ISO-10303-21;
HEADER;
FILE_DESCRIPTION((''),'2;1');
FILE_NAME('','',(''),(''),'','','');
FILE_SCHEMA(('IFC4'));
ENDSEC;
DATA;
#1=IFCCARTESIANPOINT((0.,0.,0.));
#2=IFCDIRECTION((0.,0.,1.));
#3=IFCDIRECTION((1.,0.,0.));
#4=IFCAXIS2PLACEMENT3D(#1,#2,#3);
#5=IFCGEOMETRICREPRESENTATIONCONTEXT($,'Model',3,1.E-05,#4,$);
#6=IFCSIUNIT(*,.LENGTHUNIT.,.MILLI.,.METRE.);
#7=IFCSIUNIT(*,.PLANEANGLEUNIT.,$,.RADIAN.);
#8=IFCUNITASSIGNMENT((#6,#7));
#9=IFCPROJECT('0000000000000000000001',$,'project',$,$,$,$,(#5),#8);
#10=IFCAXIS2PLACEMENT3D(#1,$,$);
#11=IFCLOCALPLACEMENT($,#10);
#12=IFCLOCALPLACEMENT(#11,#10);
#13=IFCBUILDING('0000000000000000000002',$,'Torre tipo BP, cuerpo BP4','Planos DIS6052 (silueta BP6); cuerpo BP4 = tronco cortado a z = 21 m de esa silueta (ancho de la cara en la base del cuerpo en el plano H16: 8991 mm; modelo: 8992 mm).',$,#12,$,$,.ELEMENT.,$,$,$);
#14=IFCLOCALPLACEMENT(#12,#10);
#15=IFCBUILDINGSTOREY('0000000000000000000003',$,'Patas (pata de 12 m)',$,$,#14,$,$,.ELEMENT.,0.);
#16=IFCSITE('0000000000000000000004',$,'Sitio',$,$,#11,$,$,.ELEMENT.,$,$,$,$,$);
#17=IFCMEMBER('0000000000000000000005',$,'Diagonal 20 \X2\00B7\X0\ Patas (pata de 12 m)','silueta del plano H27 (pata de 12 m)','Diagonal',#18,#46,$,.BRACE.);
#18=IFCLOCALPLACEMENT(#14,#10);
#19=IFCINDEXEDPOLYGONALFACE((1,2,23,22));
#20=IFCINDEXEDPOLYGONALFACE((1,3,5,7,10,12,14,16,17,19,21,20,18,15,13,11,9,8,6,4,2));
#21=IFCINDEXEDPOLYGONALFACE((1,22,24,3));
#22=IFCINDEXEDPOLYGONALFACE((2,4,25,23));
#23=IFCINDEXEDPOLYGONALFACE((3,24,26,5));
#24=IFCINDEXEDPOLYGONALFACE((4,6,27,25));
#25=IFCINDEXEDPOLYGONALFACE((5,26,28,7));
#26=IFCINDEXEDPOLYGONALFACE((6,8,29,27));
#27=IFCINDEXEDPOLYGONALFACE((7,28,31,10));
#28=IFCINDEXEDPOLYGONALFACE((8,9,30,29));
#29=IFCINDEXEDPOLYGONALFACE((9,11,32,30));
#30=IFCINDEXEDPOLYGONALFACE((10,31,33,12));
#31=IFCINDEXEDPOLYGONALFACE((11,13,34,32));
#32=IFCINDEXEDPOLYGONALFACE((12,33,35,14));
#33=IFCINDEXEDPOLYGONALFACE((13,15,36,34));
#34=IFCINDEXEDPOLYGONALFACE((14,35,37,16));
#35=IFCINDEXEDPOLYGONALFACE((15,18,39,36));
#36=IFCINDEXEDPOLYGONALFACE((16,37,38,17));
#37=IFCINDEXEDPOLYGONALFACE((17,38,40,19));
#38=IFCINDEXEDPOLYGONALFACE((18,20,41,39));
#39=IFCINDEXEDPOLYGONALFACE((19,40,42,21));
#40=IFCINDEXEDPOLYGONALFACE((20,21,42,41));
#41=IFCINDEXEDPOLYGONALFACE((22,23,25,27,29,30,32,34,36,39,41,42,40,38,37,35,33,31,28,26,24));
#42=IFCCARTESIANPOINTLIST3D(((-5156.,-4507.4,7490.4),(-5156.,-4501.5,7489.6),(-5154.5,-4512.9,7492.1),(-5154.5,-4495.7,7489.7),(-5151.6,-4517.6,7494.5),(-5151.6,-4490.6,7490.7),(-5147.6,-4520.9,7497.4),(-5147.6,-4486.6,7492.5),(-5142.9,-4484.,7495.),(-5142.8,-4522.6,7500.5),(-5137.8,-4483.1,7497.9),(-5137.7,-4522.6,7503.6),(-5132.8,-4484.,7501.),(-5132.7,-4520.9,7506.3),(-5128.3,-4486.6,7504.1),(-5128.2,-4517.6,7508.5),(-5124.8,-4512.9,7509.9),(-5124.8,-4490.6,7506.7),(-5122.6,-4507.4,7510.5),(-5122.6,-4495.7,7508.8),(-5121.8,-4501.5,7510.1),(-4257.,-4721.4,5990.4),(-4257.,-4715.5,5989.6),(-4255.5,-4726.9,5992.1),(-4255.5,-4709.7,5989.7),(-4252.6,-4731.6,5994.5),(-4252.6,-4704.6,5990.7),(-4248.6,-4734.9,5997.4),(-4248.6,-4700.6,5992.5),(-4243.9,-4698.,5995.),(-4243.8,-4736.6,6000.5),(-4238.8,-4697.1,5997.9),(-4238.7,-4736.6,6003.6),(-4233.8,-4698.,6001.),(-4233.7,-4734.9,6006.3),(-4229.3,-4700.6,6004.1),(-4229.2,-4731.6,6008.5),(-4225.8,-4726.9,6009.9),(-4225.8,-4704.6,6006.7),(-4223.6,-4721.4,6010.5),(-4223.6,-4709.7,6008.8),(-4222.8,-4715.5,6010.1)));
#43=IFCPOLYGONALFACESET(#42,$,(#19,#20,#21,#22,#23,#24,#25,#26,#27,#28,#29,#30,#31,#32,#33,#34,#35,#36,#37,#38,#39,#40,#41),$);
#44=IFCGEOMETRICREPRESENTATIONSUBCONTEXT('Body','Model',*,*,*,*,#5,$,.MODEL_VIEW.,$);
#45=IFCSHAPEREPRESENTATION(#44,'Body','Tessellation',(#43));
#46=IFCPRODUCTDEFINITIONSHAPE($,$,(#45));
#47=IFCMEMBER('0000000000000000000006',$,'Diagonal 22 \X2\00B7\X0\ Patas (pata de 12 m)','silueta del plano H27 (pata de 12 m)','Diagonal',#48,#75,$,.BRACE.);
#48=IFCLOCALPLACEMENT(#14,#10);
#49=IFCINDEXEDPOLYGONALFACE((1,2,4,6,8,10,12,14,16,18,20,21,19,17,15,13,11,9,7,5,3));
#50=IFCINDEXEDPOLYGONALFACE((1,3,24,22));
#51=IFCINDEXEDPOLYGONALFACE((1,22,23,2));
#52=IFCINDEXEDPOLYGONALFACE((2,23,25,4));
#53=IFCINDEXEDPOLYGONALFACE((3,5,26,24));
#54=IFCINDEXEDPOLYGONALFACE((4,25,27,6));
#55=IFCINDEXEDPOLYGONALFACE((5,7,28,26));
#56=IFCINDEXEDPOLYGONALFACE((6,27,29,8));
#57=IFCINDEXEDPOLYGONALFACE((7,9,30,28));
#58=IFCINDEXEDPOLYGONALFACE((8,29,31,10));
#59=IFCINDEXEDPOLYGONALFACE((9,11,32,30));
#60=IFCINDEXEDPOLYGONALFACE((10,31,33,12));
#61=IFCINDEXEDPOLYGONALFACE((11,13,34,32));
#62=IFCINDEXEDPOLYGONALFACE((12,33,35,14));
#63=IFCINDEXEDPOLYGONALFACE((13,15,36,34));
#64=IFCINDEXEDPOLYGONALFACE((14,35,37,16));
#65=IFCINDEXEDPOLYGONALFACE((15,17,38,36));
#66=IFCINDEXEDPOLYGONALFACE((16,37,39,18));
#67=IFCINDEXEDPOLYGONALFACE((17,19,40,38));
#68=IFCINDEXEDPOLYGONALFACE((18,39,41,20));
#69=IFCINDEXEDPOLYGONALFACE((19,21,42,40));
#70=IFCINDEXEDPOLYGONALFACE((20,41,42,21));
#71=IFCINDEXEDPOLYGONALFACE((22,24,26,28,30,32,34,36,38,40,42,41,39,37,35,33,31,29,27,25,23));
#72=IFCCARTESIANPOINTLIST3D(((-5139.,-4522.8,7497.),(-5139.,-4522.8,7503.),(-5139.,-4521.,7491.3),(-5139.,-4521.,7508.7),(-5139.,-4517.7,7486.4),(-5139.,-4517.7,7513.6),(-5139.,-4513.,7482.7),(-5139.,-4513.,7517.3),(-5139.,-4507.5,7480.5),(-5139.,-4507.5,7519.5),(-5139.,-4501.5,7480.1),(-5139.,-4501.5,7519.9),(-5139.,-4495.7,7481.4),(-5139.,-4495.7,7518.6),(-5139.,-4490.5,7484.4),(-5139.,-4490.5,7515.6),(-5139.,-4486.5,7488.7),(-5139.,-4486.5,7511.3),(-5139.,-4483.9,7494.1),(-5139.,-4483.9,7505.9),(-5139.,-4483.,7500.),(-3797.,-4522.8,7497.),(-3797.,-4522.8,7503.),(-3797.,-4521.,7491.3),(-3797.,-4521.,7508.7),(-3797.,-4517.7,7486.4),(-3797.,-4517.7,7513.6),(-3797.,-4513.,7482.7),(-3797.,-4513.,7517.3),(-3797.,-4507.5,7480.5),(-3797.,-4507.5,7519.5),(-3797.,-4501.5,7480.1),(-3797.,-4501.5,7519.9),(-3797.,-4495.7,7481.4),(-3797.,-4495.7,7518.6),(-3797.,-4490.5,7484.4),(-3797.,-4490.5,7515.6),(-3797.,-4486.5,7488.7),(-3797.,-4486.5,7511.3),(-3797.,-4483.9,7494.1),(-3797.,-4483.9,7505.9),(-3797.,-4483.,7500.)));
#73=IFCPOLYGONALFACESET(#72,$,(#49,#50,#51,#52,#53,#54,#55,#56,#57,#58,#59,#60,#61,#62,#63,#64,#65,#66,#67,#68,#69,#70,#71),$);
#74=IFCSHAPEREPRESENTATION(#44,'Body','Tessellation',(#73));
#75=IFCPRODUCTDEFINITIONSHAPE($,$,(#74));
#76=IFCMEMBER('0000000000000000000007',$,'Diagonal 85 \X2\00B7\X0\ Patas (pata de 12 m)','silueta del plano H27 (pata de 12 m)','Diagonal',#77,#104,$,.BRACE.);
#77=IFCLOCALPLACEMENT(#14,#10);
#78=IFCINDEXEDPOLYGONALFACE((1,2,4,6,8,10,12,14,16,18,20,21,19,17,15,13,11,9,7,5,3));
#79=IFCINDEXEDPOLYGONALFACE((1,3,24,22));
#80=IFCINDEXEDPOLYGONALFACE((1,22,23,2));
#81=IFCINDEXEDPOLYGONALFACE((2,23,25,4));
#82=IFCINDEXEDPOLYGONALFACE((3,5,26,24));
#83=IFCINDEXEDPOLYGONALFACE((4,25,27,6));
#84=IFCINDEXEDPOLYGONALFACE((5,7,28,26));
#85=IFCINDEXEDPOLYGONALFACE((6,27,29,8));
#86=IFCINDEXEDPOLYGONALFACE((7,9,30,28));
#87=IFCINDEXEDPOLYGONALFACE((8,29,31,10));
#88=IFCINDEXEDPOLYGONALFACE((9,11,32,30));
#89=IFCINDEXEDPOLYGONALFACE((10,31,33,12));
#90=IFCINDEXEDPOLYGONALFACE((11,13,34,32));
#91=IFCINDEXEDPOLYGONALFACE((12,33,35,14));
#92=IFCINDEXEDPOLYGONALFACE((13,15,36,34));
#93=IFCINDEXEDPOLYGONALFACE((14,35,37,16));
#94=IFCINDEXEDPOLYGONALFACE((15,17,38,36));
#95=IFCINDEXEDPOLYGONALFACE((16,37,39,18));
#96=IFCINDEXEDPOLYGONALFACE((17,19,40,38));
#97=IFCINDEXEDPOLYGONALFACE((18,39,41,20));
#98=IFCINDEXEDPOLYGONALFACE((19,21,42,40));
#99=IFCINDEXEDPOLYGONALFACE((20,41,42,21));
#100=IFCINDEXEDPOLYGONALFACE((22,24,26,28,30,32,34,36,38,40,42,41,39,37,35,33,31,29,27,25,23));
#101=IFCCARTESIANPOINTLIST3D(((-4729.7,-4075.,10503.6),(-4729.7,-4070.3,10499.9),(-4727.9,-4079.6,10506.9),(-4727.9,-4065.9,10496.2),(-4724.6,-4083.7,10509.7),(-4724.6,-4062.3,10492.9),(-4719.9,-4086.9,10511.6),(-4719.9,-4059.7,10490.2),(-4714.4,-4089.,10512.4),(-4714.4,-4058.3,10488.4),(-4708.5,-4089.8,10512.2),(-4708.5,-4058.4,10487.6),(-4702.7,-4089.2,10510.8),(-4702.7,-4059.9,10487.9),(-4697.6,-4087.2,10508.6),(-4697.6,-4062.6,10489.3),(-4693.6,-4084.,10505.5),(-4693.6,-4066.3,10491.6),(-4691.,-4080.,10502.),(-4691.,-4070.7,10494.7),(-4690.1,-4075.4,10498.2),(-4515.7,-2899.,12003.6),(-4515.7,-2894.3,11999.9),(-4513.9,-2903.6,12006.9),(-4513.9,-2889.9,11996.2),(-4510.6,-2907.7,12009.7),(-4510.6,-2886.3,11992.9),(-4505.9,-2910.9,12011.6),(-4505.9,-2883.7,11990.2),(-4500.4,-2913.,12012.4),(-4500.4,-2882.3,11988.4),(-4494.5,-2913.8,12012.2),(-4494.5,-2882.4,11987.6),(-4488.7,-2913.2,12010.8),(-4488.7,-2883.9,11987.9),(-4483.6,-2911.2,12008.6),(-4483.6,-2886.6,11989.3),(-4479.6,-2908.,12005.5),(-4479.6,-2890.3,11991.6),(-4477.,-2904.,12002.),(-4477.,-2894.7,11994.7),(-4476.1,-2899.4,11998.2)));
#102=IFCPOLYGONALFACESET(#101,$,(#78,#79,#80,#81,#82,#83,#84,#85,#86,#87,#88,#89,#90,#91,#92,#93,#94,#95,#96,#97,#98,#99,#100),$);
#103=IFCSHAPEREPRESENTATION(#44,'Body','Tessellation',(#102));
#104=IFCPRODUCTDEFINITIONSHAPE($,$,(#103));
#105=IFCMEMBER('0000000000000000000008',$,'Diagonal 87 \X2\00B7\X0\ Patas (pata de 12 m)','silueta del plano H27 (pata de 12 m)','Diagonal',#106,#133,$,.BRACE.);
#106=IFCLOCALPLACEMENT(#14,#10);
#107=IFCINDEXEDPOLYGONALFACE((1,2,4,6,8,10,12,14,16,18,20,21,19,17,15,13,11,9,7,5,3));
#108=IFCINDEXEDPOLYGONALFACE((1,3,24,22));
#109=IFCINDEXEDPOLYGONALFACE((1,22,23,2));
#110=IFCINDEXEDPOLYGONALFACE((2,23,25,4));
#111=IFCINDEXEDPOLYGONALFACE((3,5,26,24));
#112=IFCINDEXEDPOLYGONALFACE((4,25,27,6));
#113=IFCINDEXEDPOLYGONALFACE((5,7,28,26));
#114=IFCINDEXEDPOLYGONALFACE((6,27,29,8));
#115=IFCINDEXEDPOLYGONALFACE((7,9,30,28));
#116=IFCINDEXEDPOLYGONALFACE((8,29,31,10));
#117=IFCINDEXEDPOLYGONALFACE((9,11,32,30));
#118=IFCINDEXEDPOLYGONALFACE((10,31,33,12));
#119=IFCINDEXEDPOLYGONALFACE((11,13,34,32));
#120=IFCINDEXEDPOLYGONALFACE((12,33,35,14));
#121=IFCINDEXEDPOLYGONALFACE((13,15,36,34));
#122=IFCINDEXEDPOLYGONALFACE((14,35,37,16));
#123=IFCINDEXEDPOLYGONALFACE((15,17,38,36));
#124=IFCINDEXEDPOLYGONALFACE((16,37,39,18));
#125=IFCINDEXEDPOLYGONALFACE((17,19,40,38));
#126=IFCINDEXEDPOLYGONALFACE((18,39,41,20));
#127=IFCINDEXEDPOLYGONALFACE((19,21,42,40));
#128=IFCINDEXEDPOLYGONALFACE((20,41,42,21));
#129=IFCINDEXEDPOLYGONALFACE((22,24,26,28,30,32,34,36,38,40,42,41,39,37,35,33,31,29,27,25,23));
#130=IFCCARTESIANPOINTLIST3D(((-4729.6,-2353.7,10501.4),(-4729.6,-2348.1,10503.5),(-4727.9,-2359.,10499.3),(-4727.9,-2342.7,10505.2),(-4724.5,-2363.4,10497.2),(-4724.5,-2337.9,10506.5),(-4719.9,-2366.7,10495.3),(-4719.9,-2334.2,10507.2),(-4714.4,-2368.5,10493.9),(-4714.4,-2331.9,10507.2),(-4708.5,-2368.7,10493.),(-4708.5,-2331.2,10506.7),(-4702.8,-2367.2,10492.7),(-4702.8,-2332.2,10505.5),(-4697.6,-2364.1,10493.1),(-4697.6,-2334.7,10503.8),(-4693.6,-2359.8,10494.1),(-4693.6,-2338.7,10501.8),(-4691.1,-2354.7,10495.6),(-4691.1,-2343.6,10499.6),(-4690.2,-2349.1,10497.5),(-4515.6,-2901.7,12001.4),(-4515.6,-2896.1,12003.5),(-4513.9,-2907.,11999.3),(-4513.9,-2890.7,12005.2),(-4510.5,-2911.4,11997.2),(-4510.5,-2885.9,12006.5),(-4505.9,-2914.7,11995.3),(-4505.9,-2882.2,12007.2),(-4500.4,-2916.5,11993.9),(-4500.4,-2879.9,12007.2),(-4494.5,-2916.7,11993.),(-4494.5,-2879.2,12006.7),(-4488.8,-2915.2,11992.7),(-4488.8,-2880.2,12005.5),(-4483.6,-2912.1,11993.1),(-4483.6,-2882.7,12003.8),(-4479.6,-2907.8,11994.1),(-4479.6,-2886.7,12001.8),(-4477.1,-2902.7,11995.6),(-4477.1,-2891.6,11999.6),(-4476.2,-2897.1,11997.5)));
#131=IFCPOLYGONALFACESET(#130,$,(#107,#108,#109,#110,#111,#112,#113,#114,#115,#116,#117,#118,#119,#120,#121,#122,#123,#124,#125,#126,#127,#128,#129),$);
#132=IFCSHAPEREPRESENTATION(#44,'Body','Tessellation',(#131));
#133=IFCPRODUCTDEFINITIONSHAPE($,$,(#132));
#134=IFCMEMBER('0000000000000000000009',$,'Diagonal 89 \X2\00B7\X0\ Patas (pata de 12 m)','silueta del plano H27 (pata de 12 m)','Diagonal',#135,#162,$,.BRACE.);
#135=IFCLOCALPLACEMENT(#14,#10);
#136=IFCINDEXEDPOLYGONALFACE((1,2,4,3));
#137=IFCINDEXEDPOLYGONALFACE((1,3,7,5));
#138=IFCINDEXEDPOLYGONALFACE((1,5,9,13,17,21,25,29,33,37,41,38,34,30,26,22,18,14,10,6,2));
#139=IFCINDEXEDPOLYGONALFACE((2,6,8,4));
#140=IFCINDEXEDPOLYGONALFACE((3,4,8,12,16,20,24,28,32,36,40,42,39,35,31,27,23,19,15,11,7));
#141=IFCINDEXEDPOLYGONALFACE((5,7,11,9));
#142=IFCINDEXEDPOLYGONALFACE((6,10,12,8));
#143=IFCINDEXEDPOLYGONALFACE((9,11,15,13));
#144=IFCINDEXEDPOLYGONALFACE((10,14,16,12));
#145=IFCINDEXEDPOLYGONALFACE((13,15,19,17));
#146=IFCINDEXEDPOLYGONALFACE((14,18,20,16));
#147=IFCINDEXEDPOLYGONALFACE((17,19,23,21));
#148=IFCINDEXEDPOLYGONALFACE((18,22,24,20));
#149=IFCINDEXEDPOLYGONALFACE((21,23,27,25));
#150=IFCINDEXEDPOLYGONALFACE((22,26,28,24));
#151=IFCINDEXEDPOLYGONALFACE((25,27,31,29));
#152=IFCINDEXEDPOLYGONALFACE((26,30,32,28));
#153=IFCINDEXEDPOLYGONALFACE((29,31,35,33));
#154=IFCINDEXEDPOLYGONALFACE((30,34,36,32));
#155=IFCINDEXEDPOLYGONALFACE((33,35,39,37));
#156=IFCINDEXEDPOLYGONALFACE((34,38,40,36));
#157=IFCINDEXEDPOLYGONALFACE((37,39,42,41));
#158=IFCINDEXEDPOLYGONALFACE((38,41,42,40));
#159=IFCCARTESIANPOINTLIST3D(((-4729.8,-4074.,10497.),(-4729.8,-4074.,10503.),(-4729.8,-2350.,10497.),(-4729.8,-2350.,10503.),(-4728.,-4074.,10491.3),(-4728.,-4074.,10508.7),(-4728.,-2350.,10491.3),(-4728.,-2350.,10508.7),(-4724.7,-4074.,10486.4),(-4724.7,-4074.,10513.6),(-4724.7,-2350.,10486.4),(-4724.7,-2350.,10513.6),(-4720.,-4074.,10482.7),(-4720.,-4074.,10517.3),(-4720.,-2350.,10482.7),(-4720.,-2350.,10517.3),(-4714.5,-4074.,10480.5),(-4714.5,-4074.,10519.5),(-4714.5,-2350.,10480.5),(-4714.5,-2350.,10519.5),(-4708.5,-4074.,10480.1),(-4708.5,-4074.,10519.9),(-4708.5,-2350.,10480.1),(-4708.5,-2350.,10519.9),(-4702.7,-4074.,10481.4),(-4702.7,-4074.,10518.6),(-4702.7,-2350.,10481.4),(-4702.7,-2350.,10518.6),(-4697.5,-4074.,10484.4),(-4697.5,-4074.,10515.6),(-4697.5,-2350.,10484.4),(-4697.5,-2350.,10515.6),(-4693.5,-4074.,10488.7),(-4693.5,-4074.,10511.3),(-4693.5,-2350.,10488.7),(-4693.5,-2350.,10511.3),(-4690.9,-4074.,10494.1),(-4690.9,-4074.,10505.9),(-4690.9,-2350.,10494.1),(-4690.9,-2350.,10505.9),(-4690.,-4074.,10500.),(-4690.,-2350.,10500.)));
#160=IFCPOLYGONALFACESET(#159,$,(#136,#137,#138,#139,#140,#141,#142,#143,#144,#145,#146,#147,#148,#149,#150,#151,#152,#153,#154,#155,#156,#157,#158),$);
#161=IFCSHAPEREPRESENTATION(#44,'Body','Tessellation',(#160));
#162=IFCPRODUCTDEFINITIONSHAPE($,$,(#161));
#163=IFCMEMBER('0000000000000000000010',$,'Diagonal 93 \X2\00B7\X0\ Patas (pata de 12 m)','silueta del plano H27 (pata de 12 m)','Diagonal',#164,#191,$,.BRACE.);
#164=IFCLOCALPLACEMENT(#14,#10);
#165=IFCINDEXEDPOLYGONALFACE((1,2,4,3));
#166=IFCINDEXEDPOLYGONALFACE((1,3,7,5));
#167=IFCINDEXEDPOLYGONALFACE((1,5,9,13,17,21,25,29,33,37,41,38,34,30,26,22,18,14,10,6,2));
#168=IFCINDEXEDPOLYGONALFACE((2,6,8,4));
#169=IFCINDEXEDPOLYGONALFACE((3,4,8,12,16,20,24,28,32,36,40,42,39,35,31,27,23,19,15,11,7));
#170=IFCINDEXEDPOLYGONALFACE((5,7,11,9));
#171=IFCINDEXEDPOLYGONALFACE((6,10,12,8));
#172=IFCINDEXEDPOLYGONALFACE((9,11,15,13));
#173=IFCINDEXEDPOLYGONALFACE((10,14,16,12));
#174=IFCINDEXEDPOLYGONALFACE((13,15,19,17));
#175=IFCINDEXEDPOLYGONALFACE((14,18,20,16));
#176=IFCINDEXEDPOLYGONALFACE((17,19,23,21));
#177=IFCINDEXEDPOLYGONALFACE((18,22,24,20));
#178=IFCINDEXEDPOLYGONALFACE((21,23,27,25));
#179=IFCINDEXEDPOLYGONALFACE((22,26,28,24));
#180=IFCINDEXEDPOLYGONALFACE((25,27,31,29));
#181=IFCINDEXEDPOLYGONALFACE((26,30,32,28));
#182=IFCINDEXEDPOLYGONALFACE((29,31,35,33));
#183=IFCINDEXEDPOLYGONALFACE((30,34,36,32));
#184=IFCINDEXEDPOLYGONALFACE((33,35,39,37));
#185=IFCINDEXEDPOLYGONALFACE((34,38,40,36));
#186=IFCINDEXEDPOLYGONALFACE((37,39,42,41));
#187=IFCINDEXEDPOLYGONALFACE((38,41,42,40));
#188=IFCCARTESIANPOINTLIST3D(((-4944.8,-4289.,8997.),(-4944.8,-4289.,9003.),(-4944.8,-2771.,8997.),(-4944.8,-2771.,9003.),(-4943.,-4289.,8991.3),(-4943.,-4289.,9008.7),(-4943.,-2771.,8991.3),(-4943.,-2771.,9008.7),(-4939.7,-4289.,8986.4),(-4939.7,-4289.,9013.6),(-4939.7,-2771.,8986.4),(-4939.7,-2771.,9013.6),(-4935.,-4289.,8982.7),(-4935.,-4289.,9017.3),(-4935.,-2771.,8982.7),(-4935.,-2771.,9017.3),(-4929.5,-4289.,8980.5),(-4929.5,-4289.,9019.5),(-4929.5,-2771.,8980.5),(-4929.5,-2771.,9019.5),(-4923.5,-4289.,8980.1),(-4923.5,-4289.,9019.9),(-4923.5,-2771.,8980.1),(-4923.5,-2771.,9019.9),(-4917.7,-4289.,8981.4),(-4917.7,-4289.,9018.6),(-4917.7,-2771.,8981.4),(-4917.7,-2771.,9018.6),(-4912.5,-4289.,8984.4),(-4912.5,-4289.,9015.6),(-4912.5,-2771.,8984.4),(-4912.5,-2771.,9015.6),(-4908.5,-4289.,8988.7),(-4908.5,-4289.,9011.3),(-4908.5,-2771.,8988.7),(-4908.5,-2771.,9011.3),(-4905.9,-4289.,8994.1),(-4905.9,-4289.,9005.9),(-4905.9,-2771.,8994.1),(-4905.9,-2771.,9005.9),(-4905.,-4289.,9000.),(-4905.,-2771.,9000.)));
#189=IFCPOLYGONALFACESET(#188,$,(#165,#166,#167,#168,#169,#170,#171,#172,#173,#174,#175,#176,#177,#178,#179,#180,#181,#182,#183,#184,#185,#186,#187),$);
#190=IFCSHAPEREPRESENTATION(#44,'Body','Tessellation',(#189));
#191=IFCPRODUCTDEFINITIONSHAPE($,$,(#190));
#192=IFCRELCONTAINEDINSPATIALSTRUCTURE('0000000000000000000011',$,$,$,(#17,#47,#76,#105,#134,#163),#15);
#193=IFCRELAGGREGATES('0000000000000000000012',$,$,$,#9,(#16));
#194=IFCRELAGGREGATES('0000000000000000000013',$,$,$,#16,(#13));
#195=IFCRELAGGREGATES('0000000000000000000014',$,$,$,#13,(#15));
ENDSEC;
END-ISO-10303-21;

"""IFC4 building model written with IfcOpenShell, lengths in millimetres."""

from ifc_helpers import new_model, si_unit, frame, origin, origin_with_axes, place, context, subcontext, project, spatial, circle, extrude, element, save


model = new_model("IFC4")

# Units and contexts
model_context = context("Model", 3, precision=1e-05, world=origin_with_axes())
body_context = subcontext(model_context, "Body", "Model", "MODEL_VIEW")
ifc_project = project(units=[si_unit("LENGTHUNIT", "METRE", prefix="MILLI"), si_unit("PLANEANGLEUNIT", "RADIAN")], contexts=[model_context])

# Site, building, storey
site_placement = place(None, origin())
site = spatial("IfcSite", under=ifc_project, at=site_placement, Name="Sitio", CompositionType="ELEMENT")
building_placement = place(site_placement, origin())
building = spatial("IfcBuilding", under=site, at=building_placement, Name="Torre tipo BP, cuerpo BP4", Description="Planos DIS6052 (silueta BP6); cuerpo BP4 = tronco cortado a z = 21 m de esa silueta (ancho de la cara en la base del cuerpo en el plano H16: 8991 mm; modelo: 8992 mm).", CompositionType="ELEMENT")
storey_placement = place(building_placement, origin())
storey = spatial("IfcBuildingStorey", under=building, at=storey_placement, Name="Patas (pata de 12 m)", CompositionType="ELEMENT", Elevation=0.0)

# Members
member_1_placement = place(storey_placement, frame((-4240.0, -4717.0, 6000.0), z_axis=(-0.510269, 0.121466, 0.851394), x_axis=(0.062442, 0.992596, -0.104186)))
element("IfcMember", 1, at=member_1_placement, inside=storey, Name="Diagonal 20 · Patas (pata de 12 m)", Description="silueta del plano H27 (pata de 12 m)", ObjectType="Diagonal", PredefinedType="BRACE", context=body_context, shape_type="SweptSolid", body=[
    extrude(circle(Radius=20.0), None, (0.0, 0.0, 1.0), 1761.8),
])
member_2_placement = place(storey_placement, frame((-5139.0, -4503.0, 7500.0), z_axis=(1.0, 0.0, 0.0), x_axis=(0.0, 1.0, 0.0)))
element("IfcMember", 2, at=member_2_placement, inside=storey, Name="Diagonal 22 · Patas (pata de 12 m)", Description="silueta del plano H27 (pata de 12 m)", ObjectType="Diagonal", PredefinedType="BRACE", context=body_context, shape_type="SweptSolid", body=[
    extrude(circle(Radius=20.0), None, (0.0, 0.0, 1.0), 1342.0),
])
member_3_placement = place(storey_placement, frame((-4710.0, -4074.0, 10500.0), z_axis=(0.111574, 0.613135, 0.78206), x_axis=(0.993756, -0.06884, -0.087806)))
element("IfcMember", 3, at=member_3_placement, inside=storey, Name="Diagonal 85 · Patas (pata de 12 m)", Description="silueta del plano H27 (pata de 12 m)", ObjectType="Diagonal", PredefinedType="BRACE", context=body_context, shape_type="SweptSolid", body=[
    extrude(circle(Radius=20.0), None, (0.0, 0.0, 1.0), 1918.0),
])
member_4_placement = place(storey_placement, frame((-4496.0, -2898.0, 12000.0), z_axis=(-0.132817, 0.34011, -0.930959), x_axis=(0.991141, 0.045576, -0.124752)))
element("IfcMember", 4, at=member_4_placement, inside=storey, Name="Diagonal 87 · Patas (pata de 12 m)", Description="silueta del plano H27 (pata de 12 m)", ObjectType="Diagonal", PredefinedType="BRACE", context=body_context, shape_type="SweptSolid", body=[
    extrude(circle(Radius=20.0), None, (0.0, 0.0, 1.0), 1611.2),
])
member_5_placement = place(storey_placement, frame((-4710.0, -2350.0, 10500.0), z_axis=(0.0, -1.0, 0.0), x_axis=(1.0, 0.0, 0.0)))
element("IfcMember", 5, at=member_5_placement, inside=storey, Name="Diagonal 89 · Patas (pata de 12 m)", Description="silueta del plano H27 (pata de 12 m)", ObjectType="Diagonal", PredefinedType="BRACE", context=body_context, shape_type="SweptSolid", body=[
    extrude(circle(Radius=20.0), None, (0.0, 0.0, 1.0), 1724.0),
])
member_6_placement = place(storey_placement, frame((-4925.0, -4289.0, 9000.0), z_axis=(0.0, 1.0, 0.0), x_axis=(1.0, 0.0, 0.0)))
element("IfcMember", 6, at=member_6_placement, inside=storey, Name="Diagonal 93 · Patas (pata de 12 m)", Description="silueta del plano H27 (pata de 12 m)", ObjectType="Diagonal", PredefinedType="BRACE", context=body_context, shape_type="SweptSolid", body=[
    extrude(circle(Radius=20.0), None, (0.0, 0.0, 1.0), 1518.0),
])

save(model, "model.ifc")
